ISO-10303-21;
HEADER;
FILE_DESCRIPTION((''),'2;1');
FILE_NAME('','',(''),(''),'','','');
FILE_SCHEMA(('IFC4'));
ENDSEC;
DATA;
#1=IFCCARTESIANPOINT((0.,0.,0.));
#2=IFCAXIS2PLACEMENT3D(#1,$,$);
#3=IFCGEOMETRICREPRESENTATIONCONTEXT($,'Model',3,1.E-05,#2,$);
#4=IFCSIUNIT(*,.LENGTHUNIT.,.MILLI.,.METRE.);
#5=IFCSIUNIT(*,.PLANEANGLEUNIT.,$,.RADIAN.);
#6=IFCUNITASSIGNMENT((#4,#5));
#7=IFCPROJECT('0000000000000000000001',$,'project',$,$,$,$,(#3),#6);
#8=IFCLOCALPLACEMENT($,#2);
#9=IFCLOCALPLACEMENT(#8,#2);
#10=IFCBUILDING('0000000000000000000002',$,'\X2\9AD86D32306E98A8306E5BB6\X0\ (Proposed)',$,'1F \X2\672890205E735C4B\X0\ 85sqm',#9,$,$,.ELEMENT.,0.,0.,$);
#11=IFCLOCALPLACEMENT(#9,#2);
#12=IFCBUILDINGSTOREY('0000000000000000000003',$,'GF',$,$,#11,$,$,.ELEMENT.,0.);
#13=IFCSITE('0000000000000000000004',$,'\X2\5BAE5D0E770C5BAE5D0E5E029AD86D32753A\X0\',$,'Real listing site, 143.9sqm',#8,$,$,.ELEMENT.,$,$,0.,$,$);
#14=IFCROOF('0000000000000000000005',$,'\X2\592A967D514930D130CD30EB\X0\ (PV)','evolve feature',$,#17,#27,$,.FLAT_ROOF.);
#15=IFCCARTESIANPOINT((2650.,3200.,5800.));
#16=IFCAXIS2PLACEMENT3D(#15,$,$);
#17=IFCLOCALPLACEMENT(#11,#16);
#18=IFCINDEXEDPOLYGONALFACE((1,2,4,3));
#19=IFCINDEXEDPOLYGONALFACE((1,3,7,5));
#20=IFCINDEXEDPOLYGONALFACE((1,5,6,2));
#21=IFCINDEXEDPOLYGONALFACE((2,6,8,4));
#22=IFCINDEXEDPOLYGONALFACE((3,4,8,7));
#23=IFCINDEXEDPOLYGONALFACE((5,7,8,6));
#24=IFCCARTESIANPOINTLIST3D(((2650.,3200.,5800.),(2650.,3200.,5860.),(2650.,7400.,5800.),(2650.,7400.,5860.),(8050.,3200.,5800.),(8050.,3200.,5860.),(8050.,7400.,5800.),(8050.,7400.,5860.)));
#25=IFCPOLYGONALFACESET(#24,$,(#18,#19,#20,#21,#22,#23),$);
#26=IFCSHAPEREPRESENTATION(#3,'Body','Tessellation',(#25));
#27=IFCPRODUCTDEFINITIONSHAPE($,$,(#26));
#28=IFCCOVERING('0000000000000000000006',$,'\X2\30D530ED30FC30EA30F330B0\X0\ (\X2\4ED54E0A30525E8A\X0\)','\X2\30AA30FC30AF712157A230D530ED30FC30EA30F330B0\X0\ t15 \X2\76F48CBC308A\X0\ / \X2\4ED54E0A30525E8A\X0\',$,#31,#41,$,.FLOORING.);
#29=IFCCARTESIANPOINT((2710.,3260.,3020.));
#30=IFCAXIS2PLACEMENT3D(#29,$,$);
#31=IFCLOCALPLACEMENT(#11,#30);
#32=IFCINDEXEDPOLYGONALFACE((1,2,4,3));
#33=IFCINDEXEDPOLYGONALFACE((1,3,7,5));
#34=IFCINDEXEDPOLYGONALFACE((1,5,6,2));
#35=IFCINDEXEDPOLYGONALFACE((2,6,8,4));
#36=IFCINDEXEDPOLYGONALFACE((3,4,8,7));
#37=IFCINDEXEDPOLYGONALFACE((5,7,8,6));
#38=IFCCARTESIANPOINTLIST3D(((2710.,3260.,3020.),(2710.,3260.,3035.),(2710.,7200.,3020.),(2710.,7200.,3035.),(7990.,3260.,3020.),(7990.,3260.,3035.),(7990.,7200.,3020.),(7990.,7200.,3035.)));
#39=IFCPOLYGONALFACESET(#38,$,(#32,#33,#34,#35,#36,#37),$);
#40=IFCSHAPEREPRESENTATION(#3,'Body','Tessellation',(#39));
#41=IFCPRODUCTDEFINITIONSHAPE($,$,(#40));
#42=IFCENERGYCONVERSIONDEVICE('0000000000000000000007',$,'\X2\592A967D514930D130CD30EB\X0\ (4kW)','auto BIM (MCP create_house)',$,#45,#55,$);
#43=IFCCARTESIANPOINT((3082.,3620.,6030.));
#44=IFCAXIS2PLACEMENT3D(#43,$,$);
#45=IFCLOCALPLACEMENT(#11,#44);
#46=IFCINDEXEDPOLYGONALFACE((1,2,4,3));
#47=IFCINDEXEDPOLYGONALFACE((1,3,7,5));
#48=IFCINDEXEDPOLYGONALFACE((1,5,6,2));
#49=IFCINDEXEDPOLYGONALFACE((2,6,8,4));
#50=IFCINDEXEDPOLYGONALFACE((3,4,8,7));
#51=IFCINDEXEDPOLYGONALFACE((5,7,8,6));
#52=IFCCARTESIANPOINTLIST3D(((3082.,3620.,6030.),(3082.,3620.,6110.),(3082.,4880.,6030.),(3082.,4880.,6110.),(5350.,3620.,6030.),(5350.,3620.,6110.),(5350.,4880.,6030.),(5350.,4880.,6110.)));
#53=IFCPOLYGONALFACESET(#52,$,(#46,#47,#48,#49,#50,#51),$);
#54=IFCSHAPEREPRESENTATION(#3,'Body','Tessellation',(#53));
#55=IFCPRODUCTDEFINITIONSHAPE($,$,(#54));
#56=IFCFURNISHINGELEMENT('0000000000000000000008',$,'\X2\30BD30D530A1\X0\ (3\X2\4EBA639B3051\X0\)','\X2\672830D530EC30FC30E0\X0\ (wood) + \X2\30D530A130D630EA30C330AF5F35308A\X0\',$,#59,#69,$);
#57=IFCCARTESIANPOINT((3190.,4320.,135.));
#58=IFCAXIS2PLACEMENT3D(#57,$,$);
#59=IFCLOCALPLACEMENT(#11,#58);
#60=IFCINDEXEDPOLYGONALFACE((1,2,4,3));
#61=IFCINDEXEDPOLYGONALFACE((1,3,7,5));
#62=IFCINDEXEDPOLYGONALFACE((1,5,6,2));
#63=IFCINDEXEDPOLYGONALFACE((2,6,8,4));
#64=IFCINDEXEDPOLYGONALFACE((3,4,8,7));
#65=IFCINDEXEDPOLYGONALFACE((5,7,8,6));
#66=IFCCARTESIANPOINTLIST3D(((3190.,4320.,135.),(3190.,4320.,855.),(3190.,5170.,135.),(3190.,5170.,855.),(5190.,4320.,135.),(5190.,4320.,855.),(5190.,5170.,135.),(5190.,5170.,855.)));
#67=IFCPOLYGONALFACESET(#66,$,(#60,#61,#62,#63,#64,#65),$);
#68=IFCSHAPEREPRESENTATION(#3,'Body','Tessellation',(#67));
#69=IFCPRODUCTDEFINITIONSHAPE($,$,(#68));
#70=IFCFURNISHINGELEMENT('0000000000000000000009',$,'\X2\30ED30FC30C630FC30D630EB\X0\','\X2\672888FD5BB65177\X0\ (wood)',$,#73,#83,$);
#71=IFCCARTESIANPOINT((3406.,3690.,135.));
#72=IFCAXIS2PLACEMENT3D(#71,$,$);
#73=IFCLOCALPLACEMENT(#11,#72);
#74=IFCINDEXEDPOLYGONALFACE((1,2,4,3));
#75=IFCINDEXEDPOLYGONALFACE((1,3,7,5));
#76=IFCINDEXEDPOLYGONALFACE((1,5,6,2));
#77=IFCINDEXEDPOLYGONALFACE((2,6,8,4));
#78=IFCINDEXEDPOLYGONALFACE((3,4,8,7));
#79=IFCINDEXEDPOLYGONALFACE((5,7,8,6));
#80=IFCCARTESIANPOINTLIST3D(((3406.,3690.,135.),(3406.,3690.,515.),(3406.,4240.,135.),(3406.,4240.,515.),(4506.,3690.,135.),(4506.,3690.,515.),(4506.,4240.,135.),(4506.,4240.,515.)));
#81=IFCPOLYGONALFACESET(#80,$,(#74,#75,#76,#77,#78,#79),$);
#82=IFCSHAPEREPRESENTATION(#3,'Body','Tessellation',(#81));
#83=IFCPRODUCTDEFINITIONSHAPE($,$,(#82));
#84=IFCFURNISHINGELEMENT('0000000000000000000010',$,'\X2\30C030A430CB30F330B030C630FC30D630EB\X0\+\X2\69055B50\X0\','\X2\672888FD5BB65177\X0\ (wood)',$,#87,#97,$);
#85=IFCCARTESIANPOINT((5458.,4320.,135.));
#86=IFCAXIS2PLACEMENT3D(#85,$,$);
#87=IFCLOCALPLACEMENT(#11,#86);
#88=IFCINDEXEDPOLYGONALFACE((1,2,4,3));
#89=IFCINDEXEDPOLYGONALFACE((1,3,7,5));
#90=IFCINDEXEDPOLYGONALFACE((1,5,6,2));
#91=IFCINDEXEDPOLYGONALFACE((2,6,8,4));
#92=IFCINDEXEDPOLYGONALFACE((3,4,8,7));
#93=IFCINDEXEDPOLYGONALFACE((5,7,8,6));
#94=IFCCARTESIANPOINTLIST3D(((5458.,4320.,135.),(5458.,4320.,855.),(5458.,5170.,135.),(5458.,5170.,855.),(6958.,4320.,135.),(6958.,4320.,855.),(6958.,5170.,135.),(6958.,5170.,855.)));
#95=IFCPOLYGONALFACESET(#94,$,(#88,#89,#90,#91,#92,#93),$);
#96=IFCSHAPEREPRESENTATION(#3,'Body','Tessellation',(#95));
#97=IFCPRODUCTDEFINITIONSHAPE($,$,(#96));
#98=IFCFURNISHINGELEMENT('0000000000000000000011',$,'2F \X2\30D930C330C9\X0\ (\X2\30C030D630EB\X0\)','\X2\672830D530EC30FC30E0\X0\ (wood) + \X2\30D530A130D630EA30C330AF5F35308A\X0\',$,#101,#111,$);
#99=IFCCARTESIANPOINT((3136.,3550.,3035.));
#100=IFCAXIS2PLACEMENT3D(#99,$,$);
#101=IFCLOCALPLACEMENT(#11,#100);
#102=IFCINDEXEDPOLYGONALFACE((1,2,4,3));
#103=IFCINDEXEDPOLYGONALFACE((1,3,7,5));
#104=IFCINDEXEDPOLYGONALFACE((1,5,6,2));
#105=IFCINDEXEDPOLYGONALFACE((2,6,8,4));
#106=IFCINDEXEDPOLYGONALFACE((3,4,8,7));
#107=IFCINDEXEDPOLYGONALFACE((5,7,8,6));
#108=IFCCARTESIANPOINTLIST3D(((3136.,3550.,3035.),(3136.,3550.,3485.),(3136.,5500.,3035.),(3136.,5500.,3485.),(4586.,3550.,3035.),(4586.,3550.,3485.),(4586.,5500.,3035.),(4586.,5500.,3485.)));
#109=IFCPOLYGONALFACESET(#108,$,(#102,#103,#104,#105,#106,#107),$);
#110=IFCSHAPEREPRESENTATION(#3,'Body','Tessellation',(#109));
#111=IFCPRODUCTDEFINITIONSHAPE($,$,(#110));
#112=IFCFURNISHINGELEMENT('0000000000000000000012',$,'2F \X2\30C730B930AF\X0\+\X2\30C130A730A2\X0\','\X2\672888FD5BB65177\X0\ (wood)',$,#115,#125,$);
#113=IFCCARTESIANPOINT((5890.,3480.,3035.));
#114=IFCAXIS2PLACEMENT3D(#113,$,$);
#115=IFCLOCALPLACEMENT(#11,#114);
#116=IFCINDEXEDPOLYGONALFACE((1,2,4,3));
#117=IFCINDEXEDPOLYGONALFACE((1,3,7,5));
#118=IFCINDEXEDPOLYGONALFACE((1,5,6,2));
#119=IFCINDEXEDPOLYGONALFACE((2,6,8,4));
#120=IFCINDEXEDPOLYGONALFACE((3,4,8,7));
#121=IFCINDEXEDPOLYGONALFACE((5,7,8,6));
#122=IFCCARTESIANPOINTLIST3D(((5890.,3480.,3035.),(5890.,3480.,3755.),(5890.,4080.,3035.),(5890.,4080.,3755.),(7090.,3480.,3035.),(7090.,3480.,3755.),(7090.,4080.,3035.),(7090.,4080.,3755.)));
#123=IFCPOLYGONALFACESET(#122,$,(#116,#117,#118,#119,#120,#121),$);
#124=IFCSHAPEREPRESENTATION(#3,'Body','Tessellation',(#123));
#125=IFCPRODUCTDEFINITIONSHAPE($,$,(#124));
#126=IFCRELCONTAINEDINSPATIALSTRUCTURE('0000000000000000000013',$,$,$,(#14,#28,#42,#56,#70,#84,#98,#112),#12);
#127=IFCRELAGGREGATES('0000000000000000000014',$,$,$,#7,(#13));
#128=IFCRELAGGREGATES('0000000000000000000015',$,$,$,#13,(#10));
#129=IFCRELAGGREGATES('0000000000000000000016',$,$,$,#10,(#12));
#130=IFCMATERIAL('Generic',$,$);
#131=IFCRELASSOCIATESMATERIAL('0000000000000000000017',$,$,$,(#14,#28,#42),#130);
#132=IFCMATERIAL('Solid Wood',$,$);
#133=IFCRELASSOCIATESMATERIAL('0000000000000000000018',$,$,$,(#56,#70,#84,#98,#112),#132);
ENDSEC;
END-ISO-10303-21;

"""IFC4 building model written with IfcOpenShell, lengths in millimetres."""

from ifc_helpers import new_model, si_unit, frame, frame_2d, origin, place, context, project, spatial, rectangle, extrude, material, element, save


model = new_model("IFC4")

# Units and contexts
model_context = context("Model", 3, precision=1e-05, world=origin())
ifc_project = project(units=[si_unit("LENGTHUNIT", "METRE", prefix="MILLI"), si_unit("PLANEANGLEUNIT", "RADIAN")], contexts=[model_context])

# Site, building, storey
site_placement = place(None, origin())
site = spatial("IfcSite", under=ifc_project, at=site_placement, Name="宮崎県宮崎市高洲町", ObjectType="Real listing site, 143.9sqm", CompositionType="ELEMENT", RefElevation=0.0)
building_placement = place(site_placement, origin())
building = spatial("IfcBuilding", under=site, at=building_placement, Name="高洲の風の家 (Proposed)", ObjectType="1F 木造平屋 85sqm", CompositionType="ELEMENT", ElevationOfRefHeight=0.0, ElevationOfTerrain=0.0)
storey_placement = place(building_placement, origin())
storey = spatial("IfcBuildingStorey", under=building, at=storey_placement, Name="GF", CompositionType="ELEMENT", Elevation=0.0)

# Shared definitions
ifc_material_1 = material(Name="Solid Wood")

# Shared definitions
ifc_material_2 = material(Name="Generic")

# Roof
roof_placement = place(storey_placement, frame((2650.0, 3200.0, 5800.0)))
element("IfcRoof", 1, at=roof_placement, inside=storey, material=ifc_material_2, Name="太陽光パネル (PV)", Description="evolve feature", PredefinedType="FLAT_ROOF", context=model_context, shape_type="SweptSolid", body=[
    extrude(rectangle(XDim=5400.0, YDim=4200.0, at=frame_2d((2700.0, 2100.0))), frame((2650.0, 3200.0, 5800.0)), (0.0, 0.0, 1.0), 60.0),
])

# Covering
covering_placement = place(storey_placement, frame((2710.0, 3260.0, 3020.0)))
element("IfcCovering", 2, at=covering_placement, inside=storey, material=ifc_material_2, Name="フローリング (仕上げ床)", Description="オーク無垢フローリング t15 直貼り / 仕上げ床", PredefinedType="FLOORING", context=model_context, shape_type="SweptSolid", body=[
    extrude(rectangle(XDim=5280.0, YDim=3940.0, at=frame_2d((2640.0, 1970.0))), frame((2710.0, 3260.0, 3020.0)), (0.0, 0.0, 1.0), 15.0),
])

# Energy conversion device
energy_conversion_device_placement = place(storey_placement, frame((3082.0, 3620.0, 6030.0)))
element("IfcEnergyConversionDevice", 3, at=energy_conversion_device_placement, inside=storey, material=ifc_material_2, Name="太陽光パネル (4kW)", Description="auto BIM (MCP create_house)", context=model_context, shape_type="SweptSolid", body=[
    extrude(rectangle(XDim=2268.0, YDim=1260.0, at=frame_2d((1134.0, 630.0))), frame((3082.0, 3620.0, 6030.0)), (0.0, 0.0, 1.0), 80.0),
])

# Furnishing elements
furnishing_1_placement = place(storey_placement, frame((3190.0, 4320.0, 135.0)))
element("IfcFurnishingElement", 4, at=furnishing_1_placement, inside=storey, material=ifc_material_1, Name="ソファ (3人掛け)", Description="木フレーム (wood) + ファブリック張り", context=model_context, shape_type="SweptSolid", body=[
    extrude(rectangle(XDim=2000.0, YDim=850.0, at=frame_2d((1000.0, 425.0))), frame((3190.0, 4320.0, 135.0)), (0.0, 0.0, 1.0), 720.0),
])
furnishing_2_placement = place(storey_placement, frame((3406.0, 3690.0, 135.0)))
element("IfcFurnishingElement", 5, at=furnishing_2_placement, inside=storey, material=ifc_material_1, Name="ローテーブル", Description="木製家具 (wood)", context=model_context, shape_type="SweptSolid", body=[
    extrude(rectangle(XDim=1100.0, YDim=550.0, at=frame_2d((550.0, 275.0))), frame((3406.0, 3690.0, 135.0)), (0.0, 0.0, 1.0), 380.0),
])
furnishing_3_placement = place(storey_placement, frame((5458.0, 4320.0, 135.0)))
element("IfcFurnishingElement", 6, at=furnishing_3_placement, inside=storey, material=ifc_material_1, Name="ダイニングテーブル+椅子", Description="木製家具 (wood)", context=model_context, shape_type="SweptSolid", body=[
    extrude(rectangle(XDim=1500.0, YDim=850.0, at=frame_2d((750.0, 425.0))), frame((5458.0, 4320.0, 135.0)), (0.0, 0.0, 1.0), 720.0),
])
furnishing_4_placement = place(storey_placement, frame((3136.0, 3550.0, 3035.0)))
element("IfcFurnishingElement", 7, at=furnishing_4_placement, inside=storey, material=ifc_material_1, Name="2F ベッド (ダブル)", Description="木フレーム (wood) + ファブリック張り", context=model_context, shape_type="SweptSolid", body=[
    extrude(rectangle(XDim=1450.0, YDim=1950.0, at=frame_2d((725.0, 975.0))), frame((3136.0, 3550.0, 3035.0)), (0.0, 0.0, 1.0), 450.0),
])
furnishing_5_placement = place(storey_placement, frame((5890.0, 3480.0, 3035.0)))
element("IfcFurnishingElement", 8, at=furnishing_5_placement, inside=storey, material=ifc_material_1, Name="2F デスク+チェア", Description="木製家具 (wood)", context=model_context, shape_type="SweptSolid", body=[
    extrude(rectangle(XDim=1200.0, YDim=600.0, at=frame_2d((600.0, 300.0))), frame((5890.0, 3480.0, 3035.0)), (0.0, 0.0, 1.0), 720.0),
])

save(model, "model.ifc")
